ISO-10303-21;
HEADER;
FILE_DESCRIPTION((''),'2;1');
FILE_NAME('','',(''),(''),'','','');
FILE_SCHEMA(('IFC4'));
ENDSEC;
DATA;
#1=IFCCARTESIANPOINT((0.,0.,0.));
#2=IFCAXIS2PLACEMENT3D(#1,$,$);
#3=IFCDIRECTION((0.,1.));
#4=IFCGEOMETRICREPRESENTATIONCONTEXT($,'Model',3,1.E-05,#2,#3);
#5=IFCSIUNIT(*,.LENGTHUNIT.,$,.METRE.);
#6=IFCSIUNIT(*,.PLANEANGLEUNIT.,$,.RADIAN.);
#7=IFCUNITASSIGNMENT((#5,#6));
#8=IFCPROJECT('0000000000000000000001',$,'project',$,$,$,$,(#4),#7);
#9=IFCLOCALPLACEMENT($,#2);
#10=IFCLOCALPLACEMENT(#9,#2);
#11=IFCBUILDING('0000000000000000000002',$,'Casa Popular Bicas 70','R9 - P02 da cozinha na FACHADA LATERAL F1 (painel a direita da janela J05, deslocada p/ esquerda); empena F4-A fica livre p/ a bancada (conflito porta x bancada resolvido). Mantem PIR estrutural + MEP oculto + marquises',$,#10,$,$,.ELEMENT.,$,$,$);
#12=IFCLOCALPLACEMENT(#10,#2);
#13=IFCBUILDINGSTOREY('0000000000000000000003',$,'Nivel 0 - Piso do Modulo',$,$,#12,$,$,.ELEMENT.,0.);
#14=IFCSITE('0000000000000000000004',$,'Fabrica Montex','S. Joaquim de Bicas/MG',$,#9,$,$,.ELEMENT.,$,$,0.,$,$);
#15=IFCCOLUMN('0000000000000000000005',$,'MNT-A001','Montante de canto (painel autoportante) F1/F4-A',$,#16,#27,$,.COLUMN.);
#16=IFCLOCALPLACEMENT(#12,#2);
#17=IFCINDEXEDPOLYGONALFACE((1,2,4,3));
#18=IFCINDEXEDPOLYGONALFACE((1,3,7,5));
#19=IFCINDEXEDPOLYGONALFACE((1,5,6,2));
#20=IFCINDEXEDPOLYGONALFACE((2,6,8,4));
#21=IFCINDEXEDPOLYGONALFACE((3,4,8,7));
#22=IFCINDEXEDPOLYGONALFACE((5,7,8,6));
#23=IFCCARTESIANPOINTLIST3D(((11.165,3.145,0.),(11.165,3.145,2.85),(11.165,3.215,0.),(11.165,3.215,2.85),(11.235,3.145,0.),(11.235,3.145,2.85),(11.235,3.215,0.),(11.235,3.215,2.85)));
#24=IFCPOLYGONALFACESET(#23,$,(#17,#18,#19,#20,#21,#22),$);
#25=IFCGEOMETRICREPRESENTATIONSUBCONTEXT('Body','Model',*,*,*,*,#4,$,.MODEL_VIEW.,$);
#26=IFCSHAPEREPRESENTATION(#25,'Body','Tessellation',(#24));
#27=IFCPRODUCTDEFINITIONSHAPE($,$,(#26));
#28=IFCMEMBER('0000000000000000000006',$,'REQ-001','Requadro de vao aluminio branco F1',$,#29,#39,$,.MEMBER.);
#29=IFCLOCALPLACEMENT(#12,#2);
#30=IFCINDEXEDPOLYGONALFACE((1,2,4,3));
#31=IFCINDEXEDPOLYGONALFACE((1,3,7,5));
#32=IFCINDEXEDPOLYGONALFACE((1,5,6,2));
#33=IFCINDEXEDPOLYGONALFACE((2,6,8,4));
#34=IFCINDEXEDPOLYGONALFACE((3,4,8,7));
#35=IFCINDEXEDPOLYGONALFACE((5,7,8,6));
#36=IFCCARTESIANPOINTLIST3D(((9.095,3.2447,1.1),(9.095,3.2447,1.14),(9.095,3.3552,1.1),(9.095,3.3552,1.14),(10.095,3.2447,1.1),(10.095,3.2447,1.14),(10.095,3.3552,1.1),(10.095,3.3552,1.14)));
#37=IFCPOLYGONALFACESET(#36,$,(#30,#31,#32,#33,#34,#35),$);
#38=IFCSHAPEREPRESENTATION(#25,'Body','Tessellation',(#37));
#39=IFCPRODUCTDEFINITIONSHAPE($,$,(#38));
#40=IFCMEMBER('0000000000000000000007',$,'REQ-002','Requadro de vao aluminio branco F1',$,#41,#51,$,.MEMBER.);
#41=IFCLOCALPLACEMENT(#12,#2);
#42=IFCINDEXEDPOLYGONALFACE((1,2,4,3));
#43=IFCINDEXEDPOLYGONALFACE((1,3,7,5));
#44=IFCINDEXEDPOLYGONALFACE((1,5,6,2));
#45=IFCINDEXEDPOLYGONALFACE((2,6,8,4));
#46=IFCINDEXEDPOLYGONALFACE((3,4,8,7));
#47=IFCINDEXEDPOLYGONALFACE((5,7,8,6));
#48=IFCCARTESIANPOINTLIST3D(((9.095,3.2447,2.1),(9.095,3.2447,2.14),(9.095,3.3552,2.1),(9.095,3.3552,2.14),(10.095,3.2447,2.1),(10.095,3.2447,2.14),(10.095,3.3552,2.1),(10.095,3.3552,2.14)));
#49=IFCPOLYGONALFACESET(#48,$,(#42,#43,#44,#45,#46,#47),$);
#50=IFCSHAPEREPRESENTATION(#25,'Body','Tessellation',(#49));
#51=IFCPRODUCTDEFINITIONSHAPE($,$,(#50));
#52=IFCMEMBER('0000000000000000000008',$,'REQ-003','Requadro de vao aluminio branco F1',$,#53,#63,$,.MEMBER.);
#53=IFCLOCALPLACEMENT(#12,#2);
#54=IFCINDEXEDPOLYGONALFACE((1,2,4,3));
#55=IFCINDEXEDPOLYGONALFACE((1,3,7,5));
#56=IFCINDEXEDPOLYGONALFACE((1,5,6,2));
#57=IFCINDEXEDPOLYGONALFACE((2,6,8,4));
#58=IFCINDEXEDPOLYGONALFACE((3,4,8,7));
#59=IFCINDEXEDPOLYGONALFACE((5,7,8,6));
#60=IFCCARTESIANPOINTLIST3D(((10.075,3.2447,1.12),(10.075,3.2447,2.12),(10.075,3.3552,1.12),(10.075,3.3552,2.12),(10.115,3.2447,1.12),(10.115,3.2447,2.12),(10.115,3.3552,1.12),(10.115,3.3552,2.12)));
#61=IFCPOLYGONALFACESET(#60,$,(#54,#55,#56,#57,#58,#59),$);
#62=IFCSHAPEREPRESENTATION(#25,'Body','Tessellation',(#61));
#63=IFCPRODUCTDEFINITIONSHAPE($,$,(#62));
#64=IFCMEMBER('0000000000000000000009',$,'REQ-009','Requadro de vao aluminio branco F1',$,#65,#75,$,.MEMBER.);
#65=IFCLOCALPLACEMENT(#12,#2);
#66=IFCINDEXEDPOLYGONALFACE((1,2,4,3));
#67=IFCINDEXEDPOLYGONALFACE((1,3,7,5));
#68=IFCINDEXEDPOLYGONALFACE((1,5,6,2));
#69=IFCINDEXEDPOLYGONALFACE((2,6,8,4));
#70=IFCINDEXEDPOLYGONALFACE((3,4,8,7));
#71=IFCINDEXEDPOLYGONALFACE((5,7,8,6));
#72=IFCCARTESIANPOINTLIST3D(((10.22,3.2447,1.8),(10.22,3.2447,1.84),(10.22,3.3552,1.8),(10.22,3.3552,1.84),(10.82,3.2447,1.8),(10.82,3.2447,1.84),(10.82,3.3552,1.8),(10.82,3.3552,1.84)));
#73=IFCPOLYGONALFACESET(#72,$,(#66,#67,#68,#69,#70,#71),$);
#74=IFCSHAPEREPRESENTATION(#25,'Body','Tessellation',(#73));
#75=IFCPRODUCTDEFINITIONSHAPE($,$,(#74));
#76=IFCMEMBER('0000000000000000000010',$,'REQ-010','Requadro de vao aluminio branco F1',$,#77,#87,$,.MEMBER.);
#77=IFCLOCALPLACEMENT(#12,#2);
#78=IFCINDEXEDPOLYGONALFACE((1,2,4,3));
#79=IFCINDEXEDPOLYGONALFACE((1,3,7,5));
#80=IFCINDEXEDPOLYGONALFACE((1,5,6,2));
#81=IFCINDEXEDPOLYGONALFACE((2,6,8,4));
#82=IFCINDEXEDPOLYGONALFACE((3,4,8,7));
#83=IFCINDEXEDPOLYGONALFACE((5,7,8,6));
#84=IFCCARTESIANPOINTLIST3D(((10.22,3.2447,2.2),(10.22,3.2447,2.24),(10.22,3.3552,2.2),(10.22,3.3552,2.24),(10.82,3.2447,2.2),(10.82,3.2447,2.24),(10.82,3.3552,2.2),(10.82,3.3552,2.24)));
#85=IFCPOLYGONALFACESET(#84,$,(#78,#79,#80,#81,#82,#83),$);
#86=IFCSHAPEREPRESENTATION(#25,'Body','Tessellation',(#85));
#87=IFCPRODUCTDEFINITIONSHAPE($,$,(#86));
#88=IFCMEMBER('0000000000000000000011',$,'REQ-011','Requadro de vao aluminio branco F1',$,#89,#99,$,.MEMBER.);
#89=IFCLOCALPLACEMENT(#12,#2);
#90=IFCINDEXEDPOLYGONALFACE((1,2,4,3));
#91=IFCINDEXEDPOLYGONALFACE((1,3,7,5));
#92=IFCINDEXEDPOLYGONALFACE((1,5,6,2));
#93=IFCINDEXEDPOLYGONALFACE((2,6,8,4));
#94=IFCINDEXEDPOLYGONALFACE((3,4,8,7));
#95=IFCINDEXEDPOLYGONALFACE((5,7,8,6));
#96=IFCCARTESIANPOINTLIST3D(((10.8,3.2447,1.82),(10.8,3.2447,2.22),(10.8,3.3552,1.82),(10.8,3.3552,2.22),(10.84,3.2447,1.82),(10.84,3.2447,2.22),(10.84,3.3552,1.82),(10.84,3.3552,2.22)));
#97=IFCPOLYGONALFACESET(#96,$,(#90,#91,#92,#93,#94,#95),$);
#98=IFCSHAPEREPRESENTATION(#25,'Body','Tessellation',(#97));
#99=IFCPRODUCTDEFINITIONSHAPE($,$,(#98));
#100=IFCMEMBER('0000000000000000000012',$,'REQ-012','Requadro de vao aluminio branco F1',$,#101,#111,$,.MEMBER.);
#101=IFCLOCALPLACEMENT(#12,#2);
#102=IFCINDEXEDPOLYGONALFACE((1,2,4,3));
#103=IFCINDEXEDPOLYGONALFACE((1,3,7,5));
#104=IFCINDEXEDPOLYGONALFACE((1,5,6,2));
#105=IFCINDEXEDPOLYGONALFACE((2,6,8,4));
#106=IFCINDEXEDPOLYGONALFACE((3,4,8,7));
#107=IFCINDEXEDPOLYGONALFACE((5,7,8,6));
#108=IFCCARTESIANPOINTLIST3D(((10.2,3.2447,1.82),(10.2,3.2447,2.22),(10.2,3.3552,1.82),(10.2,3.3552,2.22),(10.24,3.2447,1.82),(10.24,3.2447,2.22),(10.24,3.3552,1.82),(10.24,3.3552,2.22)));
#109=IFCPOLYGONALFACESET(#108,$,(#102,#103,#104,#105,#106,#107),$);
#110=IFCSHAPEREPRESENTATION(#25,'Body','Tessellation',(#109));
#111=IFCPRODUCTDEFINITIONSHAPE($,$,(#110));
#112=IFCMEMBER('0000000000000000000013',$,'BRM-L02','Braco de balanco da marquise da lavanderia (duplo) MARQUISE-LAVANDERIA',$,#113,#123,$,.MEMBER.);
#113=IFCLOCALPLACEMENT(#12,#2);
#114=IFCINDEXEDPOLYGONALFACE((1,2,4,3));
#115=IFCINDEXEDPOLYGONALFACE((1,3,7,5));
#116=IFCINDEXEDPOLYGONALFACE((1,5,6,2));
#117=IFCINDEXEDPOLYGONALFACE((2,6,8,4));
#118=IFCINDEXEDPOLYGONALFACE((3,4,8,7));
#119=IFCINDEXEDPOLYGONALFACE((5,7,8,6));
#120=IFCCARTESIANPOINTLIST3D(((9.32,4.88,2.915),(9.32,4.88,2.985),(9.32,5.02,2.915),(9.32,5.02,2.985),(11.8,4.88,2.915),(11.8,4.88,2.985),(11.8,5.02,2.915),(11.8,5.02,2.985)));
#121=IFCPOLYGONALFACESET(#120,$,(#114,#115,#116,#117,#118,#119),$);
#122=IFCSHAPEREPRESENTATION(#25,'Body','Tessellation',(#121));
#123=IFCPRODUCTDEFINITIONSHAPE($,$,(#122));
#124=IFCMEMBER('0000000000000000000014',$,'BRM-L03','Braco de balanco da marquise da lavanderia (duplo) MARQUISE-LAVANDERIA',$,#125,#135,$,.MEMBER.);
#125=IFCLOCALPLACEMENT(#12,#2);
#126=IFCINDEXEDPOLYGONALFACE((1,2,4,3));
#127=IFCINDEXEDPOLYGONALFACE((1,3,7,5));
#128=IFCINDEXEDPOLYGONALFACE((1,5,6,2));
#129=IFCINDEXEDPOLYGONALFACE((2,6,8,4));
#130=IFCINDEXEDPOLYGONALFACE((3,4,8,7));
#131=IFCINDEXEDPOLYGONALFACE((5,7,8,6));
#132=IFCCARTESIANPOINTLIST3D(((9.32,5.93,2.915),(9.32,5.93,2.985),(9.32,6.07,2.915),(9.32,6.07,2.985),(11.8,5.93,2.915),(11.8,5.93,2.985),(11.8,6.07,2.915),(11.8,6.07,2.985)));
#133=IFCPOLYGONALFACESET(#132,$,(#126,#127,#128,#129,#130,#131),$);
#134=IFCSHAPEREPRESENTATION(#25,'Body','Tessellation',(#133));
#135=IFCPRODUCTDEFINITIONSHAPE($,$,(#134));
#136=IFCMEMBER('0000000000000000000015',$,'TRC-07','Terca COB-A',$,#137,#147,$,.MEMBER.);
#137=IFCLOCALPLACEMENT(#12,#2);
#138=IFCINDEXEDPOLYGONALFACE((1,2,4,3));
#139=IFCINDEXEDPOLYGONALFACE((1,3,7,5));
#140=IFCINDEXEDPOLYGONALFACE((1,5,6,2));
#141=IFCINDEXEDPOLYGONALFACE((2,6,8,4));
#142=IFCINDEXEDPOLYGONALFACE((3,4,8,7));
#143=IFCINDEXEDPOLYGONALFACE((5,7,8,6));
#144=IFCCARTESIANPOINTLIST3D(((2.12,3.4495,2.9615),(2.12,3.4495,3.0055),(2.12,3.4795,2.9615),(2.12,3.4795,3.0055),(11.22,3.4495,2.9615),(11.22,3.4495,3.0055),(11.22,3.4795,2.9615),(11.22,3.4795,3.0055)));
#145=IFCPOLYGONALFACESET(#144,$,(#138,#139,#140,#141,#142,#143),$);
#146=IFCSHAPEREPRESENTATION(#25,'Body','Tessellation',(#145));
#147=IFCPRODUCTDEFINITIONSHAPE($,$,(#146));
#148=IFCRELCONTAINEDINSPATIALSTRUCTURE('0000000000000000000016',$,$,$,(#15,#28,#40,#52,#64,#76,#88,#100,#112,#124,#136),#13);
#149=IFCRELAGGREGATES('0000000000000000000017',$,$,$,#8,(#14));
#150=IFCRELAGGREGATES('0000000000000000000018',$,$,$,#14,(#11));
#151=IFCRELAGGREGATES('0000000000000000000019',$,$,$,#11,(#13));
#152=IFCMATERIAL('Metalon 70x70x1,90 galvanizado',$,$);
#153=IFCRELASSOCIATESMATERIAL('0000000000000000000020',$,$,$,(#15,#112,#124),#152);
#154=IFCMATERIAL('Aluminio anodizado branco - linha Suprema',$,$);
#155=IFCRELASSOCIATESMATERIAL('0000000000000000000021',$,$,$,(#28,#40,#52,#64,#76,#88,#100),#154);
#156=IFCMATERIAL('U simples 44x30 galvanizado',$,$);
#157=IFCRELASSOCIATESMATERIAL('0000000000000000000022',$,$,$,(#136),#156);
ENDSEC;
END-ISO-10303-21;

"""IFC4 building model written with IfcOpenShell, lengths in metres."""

from ifc_helpers import new_model, si_unit, direction, frame, origin, origin_2d, place, context, subcontext, project, spatial, rectangle, extrude, material, element, save


model = new_model("IFC4")

# Units and contexts
model_context = context("Model", 3, precision=1e-05, world=origin(), true_north=direction((0.0, 1.0)))
body_context = subcontext(model_context, "Body", "Model", "MODEL_VIEW")
ifc_project = project(units=[si_unit("LENGTHUNIT", "METRE"), si_unit("PLANEANGLEUNIT", "RADIAN")], contexts=[model_context])

# Site, building, storey
site_placement = place(None, origin())
site = spatial("IfcSite", under=ifc_project, at=site_placement, Name="Fabrica Montex", Description="S. Joaquim de Bicas/MG", CompositionType="ELEMENT", RefElevation=0.0)
building_placement = place(site_placement, origin())
building = spatial("IfcBuilding", under=site, at=building_placement, Name="Casa Popular Bicas 70", Description="R9 - P02 da cozinha na FACHADA LATERAL F1 (painel a direita da janela J05, deslocada p/ esquerda); empena F4-A fica livre p/ a bancada (conflito porta x bancada resolvido). Mantem PIR estrutural + MEP oculto + marquises", CompositionType="ELEMENT")
storey_placement = place(building_placement, origin())
storey = spatial("IfcBuildingStorey", under=building, at=storey_placement, Name="Nivel 0 - Piso do Modulo", CompositionType="ELEMENT", Elevation=0.0)

# Column
ifc_material_1 = material(Name="Metalon 70x70x1,90 galvanizado")
column_placement = place(None, frame((11.2, 3.18, 0.0), z_axis=(0.0, 0.0, 1.0), x_axis=(-1.0, 0.0, 0.0)))
element("IfcColumn", 1, at=column_placement, inside=storey, material=ifc_material_1, Name="MNT-A001", Description="Montante de canto (painel autoportante) F1/F4-A", PredefinedType="COLUMN", context=body_context, shape_type="SweptSolid", body=[
    extrude(rectangle(XDim=0.07, YDim=0.07, at=origin_2d()), origin(), (0.0, 0.0, 1.0), 2.85),
])

# Members
ifc_material_2 = material(Name="Aluminio anodizado branco - linha Suprema")
for number, where, z_axis, x_axis, name in (
    (2, (10.095, 3.3, 1.12), (-1.0, 0.0, 0.0), (0.0, 0.0, 1.0), "REQ-001"),
    (3, (10.095, 3.3, 2.12), (-1.0, 0.0, 0.0), (0.0, 0.0, 1.0), "REQ-002"),
    (4, (10.095, 3.3, 1.12), (0.0, 0.0, 1.0), (-1.0, 0.0, 0.0), "REQ-003"),
):
    element("IfcMember", number, at=place(None, frame(where, z_axis=z_axis, x_axis=x_axis)), inside=storey, material=ifc_material_2, Name=name, Description="Requadro de vao aluminio branco F1", PredefinedType="MEMBER", context=body_context, shape_type="SweptSolid", body=[
        extrude(rectangle(XDim=0.04, YDim=0.1105, at=origin_2d()), origin(), (0.0, 0.0, 1.0), 1.0),
    ])
for number, where, z_axis, x_axis, name in (
    (5, (10.82, 3.3, 1.82), (-1.0, 0.0, 0.0), (0.0, 0.0, 1.0), "REQ-009"),
    (6, (10.82, 3.3, 2.22), (-1.0, 0.0, 0.0), (0.0, 0.0, 1.0), "REQ-010"),
):
    element("IfcMember", number, at=place(None, frame(where, z_axis=z_axis, x_axis=x_axis)), inside=storey, material=ifc_material_2, Name=name, Description="Requadro de vao aluminio branco F1", PredefinedType="MEMBER", context=body_context, shape_type="SweptSolid", body=[
        extrude(rectangle(XDim=0.04, YDim=0.1105, at=origin_2d()), origin(), (0.0, 0.0, 1.0), 0.6),
    ])
for number, where, z_axis, x_axis, name in (
    (7, (10.82, 3.3, 1.82), (0.0, 0.0, 1.0), (-1.0, 0.0, 0.0), "REQ-011"),
    (8, (10.22, 3.3, 1.82), (0.0, 0.0, 1.0), (-1.0, 0.0, 0.0), "REQ-012"),
):
    element("IfcMember", number, at=place(None, frame(where, z_axis=z_axis, x_axis=x_axis)), inside=storey, material=ifc_material_2, Name=name, Description="Requadro de vao aluminio branco F1", PredefinedType="MEMBER", context=body_context, shape_type="SweptSolid", body=[
        extrude(rectangle(XDim=0.04, YDim=0.1105, at=origin_2d()), origin(), (0.0, 0.0, 1.0), 0.4),
    ])
for number, where, z_axis, x_axis, name in (
    (9, (9.32, 4.95, 2.95), (1.0, 0.0, 0.0), (0.0, 0.0, 1.0), "BRM-L02"),
    (10, (9.32, 6.0, 2.95), (1.0, 0.0, 0.0), (0.0, 0.0, 1.0), "BRM-L03"),
):
    element("IfcMember", number, at=place(storey_placement, frame(where, z_axis=z_axis, x_axis=x_axis)), inside=storey, material=ifc_material_1, Name=name, Description="Braco de balanco da marquise da lavanderia (duplo) MARQUISE-LAVANDERIA", PredefinedType="MEMBER", context=body_context, shape_type="SweptSolid", body=[
        extrude(rectangle(XDim=0.07, YDim=0.14, at=origin_2d()), origin(), (0.0, 0.0, 1.0), 2.48),
    ])
ifc_material_3 = material(Name="U simples 44x30 galvanizado")
member_placement = place(None, frame((11.22, 3.4645, 2.9835), z_axis=(-1.0, 0.0, 0.0), x_axis=(0.0, 0.0, 1.0)))
element("IfcMember", 11, at=member_placement, inside=storey, material=ifc_material_3, Name="TRC-07", Description="Terca COB-A", PredefinedType="MEMBER", context=body_context, shape_type="SweptSolid", body=[
    extrude(rectangle(XDim=0.044, YDim=0.03, at=origin_2d()), origin(), (0.0, 0.0, 1.0), 9.1),
])

save(model, "model.ifc")
